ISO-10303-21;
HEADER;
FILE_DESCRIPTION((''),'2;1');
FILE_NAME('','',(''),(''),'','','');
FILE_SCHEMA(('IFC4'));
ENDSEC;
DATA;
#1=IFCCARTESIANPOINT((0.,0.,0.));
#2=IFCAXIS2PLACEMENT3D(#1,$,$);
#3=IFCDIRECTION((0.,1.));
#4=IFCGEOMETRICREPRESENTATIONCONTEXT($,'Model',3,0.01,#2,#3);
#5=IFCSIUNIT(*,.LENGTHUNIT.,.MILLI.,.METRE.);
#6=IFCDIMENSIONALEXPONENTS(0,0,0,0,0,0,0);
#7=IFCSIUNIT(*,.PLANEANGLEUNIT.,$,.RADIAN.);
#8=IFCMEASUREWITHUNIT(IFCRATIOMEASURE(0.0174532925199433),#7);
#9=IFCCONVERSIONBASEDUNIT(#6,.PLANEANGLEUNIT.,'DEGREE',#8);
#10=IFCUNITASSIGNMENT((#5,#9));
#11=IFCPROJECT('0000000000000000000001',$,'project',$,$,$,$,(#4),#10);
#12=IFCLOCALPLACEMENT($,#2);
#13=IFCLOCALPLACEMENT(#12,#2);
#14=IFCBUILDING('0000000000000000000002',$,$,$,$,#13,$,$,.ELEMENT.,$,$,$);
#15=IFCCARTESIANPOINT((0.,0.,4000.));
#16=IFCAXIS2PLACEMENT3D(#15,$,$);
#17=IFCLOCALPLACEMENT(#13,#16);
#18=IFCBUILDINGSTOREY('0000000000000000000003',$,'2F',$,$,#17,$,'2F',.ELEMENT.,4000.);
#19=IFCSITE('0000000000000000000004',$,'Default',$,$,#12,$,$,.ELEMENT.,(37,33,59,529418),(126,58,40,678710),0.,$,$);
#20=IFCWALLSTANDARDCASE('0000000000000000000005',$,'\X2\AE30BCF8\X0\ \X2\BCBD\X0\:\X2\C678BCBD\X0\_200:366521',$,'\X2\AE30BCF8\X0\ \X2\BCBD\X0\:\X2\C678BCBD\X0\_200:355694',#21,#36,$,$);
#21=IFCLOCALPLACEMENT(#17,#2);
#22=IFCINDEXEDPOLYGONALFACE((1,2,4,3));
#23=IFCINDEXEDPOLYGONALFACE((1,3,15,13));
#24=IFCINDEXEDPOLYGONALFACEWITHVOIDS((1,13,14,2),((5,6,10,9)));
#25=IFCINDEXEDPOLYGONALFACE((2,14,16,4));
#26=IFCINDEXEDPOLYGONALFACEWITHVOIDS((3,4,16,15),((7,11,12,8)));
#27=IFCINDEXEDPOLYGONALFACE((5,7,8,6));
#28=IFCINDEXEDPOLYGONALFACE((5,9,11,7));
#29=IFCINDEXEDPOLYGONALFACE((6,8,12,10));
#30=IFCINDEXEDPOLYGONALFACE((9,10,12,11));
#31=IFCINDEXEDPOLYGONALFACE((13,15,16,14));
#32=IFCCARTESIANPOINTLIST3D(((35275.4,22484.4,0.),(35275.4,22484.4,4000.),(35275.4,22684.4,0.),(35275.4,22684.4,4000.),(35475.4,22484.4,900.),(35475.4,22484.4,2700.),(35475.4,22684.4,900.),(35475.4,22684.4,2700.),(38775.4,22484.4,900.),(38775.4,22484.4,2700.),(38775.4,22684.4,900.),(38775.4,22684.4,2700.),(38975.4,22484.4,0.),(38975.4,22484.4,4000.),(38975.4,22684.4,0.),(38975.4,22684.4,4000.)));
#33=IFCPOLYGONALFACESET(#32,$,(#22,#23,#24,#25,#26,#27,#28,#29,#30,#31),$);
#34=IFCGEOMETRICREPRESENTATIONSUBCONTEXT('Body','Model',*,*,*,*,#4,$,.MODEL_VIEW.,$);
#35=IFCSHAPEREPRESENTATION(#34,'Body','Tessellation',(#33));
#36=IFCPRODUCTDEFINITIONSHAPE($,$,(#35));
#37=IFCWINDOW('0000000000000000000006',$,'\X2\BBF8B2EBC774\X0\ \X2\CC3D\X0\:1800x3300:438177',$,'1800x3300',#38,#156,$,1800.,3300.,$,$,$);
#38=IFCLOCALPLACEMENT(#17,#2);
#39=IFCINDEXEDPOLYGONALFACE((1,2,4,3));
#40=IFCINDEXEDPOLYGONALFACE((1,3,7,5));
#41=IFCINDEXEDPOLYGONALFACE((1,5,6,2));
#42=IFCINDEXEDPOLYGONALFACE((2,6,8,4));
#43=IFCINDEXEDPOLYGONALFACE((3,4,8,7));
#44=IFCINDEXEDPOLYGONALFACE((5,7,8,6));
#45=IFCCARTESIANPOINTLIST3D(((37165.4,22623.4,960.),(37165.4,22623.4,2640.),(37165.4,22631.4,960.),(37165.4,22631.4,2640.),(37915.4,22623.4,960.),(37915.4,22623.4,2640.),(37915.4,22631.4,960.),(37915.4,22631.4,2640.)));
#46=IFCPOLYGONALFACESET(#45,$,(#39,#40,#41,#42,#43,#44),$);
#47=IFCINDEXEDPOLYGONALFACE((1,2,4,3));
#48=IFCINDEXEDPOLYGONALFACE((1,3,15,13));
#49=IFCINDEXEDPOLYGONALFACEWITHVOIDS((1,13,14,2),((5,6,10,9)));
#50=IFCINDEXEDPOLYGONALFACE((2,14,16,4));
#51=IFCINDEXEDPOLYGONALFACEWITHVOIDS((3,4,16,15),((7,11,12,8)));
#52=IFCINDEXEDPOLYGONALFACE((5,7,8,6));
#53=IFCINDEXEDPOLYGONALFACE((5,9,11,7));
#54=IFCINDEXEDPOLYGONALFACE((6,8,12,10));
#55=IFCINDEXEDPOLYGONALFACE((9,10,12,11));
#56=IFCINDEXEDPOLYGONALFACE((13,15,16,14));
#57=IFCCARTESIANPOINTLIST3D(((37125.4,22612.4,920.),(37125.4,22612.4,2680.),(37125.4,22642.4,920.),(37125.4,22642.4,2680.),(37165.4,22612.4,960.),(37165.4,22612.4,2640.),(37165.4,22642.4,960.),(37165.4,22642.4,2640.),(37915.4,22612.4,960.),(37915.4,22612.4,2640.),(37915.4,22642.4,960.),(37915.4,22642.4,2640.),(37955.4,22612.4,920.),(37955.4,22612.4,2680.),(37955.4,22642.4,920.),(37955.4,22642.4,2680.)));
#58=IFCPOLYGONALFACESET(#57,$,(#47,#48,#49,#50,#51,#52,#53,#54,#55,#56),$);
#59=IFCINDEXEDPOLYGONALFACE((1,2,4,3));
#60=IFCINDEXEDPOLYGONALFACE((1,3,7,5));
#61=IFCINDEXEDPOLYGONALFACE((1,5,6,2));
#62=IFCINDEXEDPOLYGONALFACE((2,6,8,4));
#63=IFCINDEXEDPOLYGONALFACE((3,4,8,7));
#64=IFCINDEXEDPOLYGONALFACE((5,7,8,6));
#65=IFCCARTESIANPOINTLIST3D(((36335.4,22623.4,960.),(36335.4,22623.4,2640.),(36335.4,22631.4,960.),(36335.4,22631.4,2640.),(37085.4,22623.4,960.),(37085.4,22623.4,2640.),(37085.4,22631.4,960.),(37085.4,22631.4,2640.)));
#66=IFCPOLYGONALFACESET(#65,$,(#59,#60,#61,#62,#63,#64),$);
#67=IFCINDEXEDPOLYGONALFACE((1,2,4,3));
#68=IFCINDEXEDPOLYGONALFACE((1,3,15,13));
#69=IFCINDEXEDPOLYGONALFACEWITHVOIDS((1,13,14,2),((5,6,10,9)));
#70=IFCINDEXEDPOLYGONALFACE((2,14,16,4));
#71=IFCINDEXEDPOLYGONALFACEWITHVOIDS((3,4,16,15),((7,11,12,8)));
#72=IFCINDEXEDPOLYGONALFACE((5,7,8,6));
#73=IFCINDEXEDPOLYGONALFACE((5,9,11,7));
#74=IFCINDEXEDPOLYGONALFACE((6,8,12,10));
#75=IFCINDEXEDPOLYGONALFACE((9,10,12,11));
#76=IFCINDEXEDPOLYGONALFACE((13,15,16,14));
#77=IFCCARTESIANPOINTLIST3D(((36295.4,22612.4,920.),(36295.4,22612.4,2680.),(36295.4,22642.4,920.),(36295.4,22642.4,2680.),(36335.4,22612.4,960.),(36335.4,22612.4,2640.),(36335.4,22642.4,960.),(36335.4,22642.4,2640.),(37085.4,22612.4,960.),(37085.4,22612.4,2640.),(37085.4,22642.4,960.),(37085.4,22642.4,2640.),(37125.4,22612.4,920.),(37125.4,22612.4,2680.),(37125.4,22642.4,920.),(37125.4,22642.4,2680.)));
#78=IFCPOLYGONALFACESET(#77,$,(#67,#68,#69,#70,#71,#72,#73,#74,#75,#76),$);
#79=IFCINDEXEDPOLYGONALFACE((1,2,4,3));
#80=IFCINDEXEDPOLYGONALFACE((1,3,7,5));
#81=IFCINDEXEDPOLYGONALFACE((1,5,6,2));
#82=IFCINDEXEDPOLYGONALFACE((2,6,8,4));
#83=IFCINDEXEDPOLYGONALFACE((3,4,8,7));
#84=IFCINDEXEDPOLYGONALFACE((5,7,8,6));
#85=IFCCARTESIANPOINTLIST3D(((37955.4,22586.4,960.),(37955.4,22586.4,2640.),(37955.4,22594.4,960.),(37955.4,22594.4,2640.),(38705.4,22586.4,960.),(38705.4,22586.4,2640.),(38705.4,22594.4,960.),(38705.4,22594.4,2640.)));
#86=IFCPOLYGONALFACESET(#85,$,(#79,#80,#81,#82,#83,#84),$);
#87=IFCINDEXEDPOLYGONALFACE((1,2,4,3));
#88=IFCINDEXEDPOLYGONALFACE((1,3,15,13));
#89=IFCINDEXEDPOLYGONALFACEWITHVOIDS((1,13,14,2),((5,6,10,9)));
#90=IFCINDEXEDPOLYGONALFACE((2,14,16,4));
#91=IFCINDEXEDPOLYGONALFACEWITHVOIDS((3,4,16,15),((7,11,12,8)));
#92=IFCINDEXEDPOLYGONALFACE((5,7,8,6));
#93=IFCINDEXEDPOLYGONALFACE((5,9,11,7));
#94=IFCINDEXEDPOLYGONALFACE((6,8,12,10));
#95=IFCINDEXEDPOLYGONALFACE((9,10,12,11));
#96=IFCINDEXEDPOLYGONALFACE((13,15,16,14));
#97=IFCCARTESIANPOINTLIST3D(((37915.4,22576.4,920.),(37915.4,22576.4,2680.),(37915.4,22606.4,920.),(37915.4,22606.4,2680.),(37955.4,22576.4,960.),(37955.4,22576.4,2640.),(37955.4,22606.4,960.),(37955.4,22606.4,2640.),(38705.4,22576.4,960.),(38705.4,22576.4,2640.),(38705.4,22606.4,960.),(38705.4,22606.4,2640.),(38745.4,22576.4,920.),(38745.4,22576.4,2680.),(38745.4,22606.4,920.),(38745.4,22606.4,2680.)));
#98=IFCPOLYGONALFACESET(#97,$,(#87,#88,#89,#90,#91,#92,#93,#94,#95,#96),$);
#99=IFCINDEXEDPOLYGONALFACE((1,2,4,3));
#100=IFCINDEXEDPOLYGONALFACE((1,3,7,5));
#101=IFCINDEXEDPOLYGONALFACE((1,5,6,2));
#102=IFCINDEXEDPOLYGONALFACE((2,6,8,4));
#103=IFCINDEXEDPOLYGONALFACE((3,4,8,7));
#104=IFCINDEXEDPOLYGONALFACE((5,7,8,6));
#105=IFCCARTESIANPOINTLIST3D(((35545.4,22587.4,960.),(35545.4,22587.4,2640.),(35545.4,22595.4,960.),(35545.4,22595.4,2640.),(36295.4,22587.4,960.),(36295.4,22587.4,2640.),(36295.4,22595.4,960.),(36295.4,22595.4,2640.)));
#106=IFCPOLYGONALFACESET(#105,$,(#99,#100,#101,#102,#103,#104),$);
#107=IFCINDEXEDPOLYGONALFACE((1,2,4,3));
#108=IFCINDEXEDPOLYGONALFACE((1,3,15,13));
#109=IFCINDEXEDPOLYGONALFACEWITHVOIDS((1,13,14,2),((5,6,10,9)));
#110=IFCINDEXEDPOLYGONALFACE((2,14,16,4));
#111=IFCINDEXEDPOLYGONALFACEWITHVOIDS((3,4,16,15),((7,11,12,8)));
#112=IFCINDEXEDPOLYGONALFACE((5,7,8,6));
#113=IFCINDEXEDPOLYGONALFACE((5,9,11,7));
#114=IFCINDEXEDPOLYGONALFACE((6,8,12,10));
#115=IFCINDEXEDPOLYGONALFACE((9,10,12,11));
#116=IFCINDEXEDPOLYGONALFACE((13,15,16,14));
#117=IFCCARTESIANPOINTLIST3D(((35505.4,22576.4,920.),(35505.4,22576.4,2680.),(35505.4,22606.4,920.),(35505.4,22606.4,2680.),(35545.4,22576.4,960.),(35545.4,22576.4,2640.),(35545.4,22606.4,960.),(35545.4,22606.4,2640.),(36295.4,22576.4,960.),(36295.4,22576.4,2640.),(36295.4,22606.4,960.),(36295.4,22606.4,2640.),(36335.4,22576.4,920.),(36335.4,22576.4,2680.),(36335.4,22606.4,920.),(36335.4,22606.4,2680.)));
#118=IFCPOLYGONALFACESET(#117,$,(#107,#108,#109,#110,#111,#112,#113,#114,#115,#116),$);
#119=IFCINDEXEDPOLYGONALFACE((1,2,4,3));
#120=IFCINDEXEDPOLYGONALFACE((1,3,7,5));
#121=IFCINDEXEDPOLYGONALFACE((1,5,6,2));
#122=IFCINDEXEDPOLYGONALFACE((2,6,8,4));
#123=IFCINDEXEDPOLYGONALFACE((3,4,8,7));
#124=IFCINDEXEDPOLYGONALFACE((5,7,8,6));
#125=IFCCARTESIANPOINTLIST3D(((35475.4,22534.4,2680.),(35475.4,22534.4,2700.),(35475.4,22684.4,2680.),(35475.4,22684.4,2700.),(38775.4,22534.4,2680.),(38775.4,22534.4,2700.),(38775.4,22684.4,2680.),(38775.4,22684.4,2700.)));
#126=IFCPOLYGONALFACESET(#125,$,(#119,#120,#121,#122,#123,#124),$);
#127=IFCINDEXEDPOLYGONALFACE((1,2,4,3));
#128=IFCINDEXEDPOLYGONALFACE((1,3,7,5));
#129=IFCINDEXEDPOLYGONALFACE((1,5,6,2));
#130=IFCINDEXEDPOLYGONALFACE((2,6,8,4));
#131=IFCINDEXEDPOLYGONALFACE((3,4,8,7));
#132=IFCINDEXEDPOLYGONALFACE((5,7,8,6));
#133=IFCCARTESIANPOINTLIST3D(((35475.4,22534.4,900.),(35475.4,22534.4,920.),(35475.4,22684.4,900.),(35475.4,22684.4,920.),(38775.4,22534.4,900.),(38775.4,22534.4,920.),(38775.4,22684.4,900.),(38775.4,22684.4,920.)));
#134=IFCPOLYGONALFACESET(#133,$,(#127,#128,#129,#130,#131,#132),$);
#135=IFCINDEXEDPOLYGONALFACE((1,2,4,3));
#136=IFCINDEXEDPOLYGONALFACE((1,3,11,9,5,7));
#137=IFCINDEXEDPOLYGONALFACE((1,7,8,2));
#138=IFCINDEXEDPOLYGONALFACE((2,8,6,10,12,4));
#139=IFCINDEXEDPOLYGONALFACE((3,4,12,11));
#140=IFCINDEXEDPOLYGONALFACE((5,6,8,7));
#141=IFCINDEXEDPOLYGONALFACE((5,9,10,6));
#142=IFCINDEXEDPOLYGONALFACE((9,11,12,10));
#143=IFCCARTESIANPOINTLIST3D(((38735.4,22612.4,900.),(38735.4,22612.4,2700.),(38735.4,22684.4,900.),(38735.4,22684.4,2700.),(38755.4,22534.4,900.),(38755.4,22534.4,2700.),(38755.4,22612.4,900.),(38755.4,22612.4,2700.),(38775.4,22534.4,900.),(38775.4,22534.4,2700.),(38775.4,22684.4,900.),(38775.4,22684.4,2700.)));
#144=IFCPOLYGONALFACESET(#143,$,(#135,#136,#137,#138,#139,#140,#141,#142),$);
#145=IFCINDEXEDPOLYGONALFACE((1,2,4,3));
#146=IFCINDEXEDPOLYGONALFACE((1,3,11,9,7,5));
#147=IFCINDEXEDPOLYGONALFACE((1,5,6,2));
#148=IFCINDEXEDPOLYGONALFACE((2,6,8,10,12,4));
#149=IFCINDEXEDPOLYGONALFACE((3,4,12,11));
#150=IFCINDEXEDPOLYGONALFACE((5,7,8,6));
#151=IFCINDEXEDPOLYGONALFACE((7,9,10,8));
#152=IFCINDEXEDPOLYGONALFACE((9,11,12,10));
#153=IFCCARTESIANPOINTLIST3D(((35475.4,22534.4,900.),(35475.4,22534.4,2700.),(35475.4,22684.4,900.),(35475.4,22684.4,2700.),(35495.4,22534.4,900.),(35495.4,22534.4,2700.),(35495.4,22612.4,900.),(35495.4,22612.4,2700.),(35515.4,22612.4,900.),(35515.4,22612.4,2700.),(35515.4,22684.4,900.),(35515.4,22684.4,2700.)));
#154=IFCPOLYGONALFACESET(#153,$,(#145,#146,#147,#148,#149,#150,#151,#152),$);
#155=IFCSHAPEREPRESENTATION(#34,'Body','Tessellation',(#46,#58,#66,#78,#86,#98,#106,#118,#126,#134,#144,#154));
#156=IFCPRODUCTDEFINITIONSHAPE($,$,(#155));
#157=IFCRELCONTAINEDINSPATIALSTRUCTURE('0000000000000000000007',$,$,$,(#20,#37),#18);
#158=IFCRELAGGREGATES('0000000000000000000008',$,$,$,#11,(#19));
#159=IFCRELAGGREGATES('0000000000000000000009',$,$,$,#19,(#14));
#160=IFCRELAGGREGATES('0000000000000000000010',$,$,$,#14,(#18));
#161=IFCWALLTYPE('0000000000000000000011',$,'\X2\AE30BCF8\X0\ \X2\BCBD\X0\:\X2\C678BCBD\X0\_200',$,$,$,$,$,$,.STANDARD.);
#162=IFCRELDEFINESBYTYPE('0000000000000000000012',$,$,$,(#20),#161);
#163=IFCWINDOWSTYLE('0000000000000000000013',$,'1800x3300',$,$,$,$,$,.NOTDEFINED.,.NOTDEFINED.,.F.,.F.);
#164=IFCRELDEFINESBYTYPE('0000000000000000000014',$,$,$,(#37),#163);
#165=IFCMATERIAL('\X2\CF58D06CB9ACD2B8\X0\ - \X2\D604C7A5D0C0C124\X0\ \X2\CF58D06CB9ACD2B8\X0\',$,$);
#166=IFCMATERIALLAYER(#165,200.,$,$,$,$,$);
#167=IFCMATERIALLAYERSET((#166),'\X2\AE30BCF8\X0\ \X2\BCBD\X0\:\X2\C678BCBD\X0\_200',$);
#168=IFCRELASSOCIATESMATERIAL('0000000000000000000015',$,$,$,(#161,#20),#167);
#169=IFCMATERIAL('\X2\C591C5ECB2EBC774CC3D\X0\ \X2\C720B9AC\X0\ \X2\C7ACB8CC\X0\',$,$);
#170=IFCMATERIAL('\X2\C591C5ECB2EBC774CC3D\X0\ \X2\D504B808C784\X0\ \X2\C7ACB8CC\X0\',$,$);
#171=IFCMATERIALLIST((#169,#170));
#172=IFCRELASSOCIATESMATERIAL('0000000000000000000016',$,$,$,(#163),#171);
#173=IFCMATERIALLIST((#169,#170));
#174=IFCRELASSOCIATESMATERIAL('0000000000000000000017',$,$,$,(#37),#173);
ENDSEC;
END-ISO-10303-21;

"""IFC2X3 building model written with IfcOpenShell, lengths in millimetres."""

from ifc_helpers import new_model, entity, si_unit, converted_unit, direction, frame, frame_2d, origin, origin_2d_with_axis, place, context, subcontext, project, spatial, polyline, rectangle, outline, extrude, source, transform, mapped, material, material_list, layer, layer_set, layer_usage, type_object, type_shapes, element, fill, save


model = new_model("IFC2X3")

# Units and contexts
model_context = context("Model", 3, precision=0.01, world=origin(), true_north=direction((0.0, 1.0)))
body_context = subcontext(model_context, "Body", "Model", "MODEL_VIEW")
ifc_project = project(units=[si_unit("LENGTHUNIT", "METRE", prefix="MILLI"), converted_unit("PLANEANGLEUNIT", "DEGREE", entity("IfcRatioMeasure", 0.0174532925199433), si_unit("PLANEANGLEUNIT", "RADIAN"), dimensions=[0, 0, 0, 0, 0, 0, 0])], contexts=[model_context])

# Site, building, storey
site_placement = place(None, origin())
site = spatial("IfcSite", under=ifc_project, at=site_placement, Name="Default", CompositionType="ELEMENT", RefLatitude=(37, 33, 59, 529418), RefLongitude=(126, 58, 40, 678710), RefElevation=0.0)
building_placement = place(site_placement, origin())
building = spatial("IfcBuilding", under=site, at=building_placement, CompositionType="ELEMENT")
storey_placement = place(building_placement, frame((0.0, 0.0, 4000.0)))
storey = spatial("IfcBuildingStorey", under=building, at=storey_placement, Name="2F", LongName="2F", CompositionType="ELEMENT", Elevation=4000.0)

# Shared definitions
ifc_material_1 = material(Name="콘크리트 - 현장타설 콘크리트")

# Wall, opening, window
ifc_layer_1 = layer(ifc_material_1, 200.0)
ifc_layer_set_1 = layer_set([ifc_layer_1], Name="기본 벽:외벽_200")
ifc_layer_usage_1 = layer_usage(ifc_layer_set_1, "AXIS2", "NEGATIVE", 100.0)
wall_type_1 = type_object("IfcWallType", Name="기본 벽:외벽_200", PredefinedType="STANDARD", material=ifc_layer_set_1)
wall_1_placement = place(storey_placement, frame((38975.4, 22584.4, 0.0), z_axis=(0.0, 0.0, 1.0), x_axis=(-1.0, 0.0, 0.0)))
wall_1 = element("IfcWallStandardCase", 1, at=wall_1_placement, inside=storey, type_object=wall_type_1, material=ifc_layer_usage_1, Name="기본 벽:외벽_200:366521", ObjectType="기본 벽:외벽_200:355694", context=body_context, shape_type="SweptSolid", body=[
    extrude(rectangle(XDim=3700.0, YDim=200.0, at=frame_2d((1850.0, 0.0), x_axis=(-1.0, 0.0))), origin(), (0.0, 0.0, 1.0), 4000.0),
])
opening_1_placement = place(wall_1_placement, frame((3500.0, 100.0, 900.0)))
opening_1 = element("IfcOpeningElement", 2, at=opening_1_placement, cuts=wall_1, ObjectType="Opening", context=body_context, shape_type="SweptSolid", body=[
    extrude(rectangle(XDim=1800.0, YDim=3300.0, at=frame_2d((900.0, 1650.0), x_axis=(1.0, 0.0))), frame((0.0, 0.0, 0.0), z_axis=(0.0, -1.0, 0.0), x_axis=(0.0, 0.0, 1.0)), (0.0, 0.0, 1.0), 200.0),
])
ifc_material_2 = material(Name="양여닫이창 유리 재료")
ifc_material_3 = material(Name="양여닫이창 프레임 재료")
ifc_material_list_1 = material_list([ifc_material_2, ifc_material_3])
ifc_material_list_2 = material_list([ifc_material_2, ifc_material_3])
window_style_1 = type_object("IfcWindowStyle", Name="1800x3300", ConstructionType="NOTDEFINED", OperationType="NOTDEFINED", ParameterTakesPrecedence=False, Sizeable=False, material=ifc_material_list_2)
shared_shape_1 = source(origin(), body_context, "Body", "SweptSolid", [
    extrude(rectangle(XDim=8.0, YDim=750.0, at=frame_2d((0.0, 0.0), x_axis=(1.0, 0.0))), frame((2065.0, 143.0, 60.0), z_axis=(0.0, 0.0, 1.0), x_axis=(0.0, 1.0, 0.0)), (0.0, 0.0, 1.0), 1680.0),
    extrude(outline(polyline([(-880.0, -415.0), (880.0, -415.0), (880.0, 415.0), (-880.0, 415.0), (-880.0, -415.0)]), holes=[polyline([(840.0, -375.0), (-840.0, -375.0), (-840.0, 375.0), (840.0, 375.0), (840.0, -375.0)])]), frame((2065.0, 128.0, 900.0), z_axis=(0.0, 1.0, 0.0), x_axis=(0.0, 0.0, -1.0)), (0.0, 0.0, 1.0), 30.0),
    extrude(rectangle(XDim=8.0, YDim=750.0, at=frame_2d((0.0, 0.0), x_axis=(1.0, 0.0))), frame((1235.0, 143.0, 60.0), z_axis=(0.0, 0.0, 1.0), x_axis=(0.0, 1.0, 0.0)), (0.0, 0.0, 1.0), 1680.0),
    extrude(outline(polyline([(-880.0, -415.0), (880.0, -415.0), (880.0, 415.0), (-880.0, 415.0), (-880.0, -415.0)]), holes=[polyline([(840.0, -375.0), (-840.0, -375.0), (-840.0, 375.0), (840.0, 375.0), (840.0, -375.0)])]), frame((1235.0, 128.0, 900.0), z_axis=(0.0, 1.0, 0.0), x_axis=(0.0, 0.0, -1.0)), (0.0, 0.0, 1.0), 30.0),
    extrude(rectangle(XDim=8.0, YDim=750.0, at=frame_2d((0.0, 0.0), x_axis=(1.0, 0.0))), frame((2855.0, 106.0, 60.0), z_axis=(0.0, 0.0, 1.0), x_axis=(0.0, 1.0, 0.0)), (0.0, 0.0, 1.0), 1680.0),
    extrude(outline(polyline([(-880.0, -415.0), (880.0, -415.0), (880.0, 415.0), (-880.0, 415.0), (-880.0, -415.0)]), holes=[polyline([(840.0, -375.0), (-840.0, -375.0), (-840.0, 375.0), (840.0, 375.0), (840.0, -375.0)])]), frame((2855.0, 92.0, 900.0), z_axis=(0.0, 1.0, 0.0), x_axis=(0.0, 0.0, -1.0)), (0.0, 0.0, 1.0), 30.0),
    extrude(rectangle(XDim=8.0, YDim=750.0, at=origin_2d_with_axis()), frame((445.0, 107.0, 60.0), z_axis=(0.0, 0.0, 1.0), x_axis=(0.0, 1.0, 0.0)), (0.0, 0.0, 1.0), 1680.0),
    extrude(outline(polyline([(-880.0, -415.0), (880.0, -415.0), (880.0, 415.0), (-880.0, 415.0), (-880.0, -415.0)]), holes=[polyline([(840.0, -375.0), (-840.0, -375.0), (-840.0, 375.0), (840.0, 375.0), (840.0, -375.0)])]), frame((445.0, 92.0, 900.0), z_axis=(0.0, 1.0, 0.0), x_axis=(0.0, 0.0, -1.0)), (0.0, 0.0, 1.0), 30.0),
    extrude(rectangle(XDim=3300.0, YDim=150.0, at=origin_2d_with_axis()), frame((1650.0, 125.0, 1780.0), z_axis=(0.0, 0.0, 1.0), x_axis=(-1.0, 0.0, 0.0)), (0.0, 0.0, 1.0), 20.0),
    extrude(rectangle(XDim=3300.0, YDim=150.0, at=origin_2d_with_axis()), frame((1650.0, 125.0, 0.0), z_axis=(0.0, 0.0, 1.0), x_axis=(-1.0, 0.0, 0.0)), (0.0, 0.0, 1.0), 20.0),
    extrude(outline(polyline([(-74.0, -20.0), (-2.0, -20.0), (-2.0, 0.0), (76.0, 0.0), (76.0, 20.0), (-74.0, 20.0), (-74.0, -20.0)])), frame((3280.0, 126.0, 0.0), z_axis=(0.0, 0.0, 1.0), x_axis=(0.0, -1.0, 0.0)), (0.0, 0.0, 1.0), 1800.0),
    extrude(outline(polyline([(-20.0, -74.0), (20.0, -74.0), (20.0, 76.0), (0.0, 76.0), (0.0, -2.0), (-20.0, -2.0), (-20.0, -74.0)])), frame((20.0, 126.0, 0.0), z_axis=(0.0, 0.0, 1.0), x_axis=(-1.0, 0.0, 0.0)), (0.0, 0.0, 1.0), 1800.0),
])
type_shapes(window_style_1, [shared_shape_1])
window_1_placement = place(opening_1_placement, frame((0.0, 0.0, 0.0), z_axis=(0.0, 0.0, 1.0), x_axis=(-1.0, 0.0, 0.0)))
window_1 = element("IfcWindow", 3, at=window_1_placement, inside=storey, type_object=window_style_1, material=ifc_material_list_1, Name="미닫이 창:1800x3300:438177", ObjectType="1800x3300", OverallHeight=1800.0, OverallWidth=3300.0, context=body_context, shape_type="MappedRepresentation", body=[
    mapped(shared_shape_1, transform((0.0, 0.0, 0.0), scale=1.0)),
])
fill(opening_1, window_1)

save(model, "model.ifc")
